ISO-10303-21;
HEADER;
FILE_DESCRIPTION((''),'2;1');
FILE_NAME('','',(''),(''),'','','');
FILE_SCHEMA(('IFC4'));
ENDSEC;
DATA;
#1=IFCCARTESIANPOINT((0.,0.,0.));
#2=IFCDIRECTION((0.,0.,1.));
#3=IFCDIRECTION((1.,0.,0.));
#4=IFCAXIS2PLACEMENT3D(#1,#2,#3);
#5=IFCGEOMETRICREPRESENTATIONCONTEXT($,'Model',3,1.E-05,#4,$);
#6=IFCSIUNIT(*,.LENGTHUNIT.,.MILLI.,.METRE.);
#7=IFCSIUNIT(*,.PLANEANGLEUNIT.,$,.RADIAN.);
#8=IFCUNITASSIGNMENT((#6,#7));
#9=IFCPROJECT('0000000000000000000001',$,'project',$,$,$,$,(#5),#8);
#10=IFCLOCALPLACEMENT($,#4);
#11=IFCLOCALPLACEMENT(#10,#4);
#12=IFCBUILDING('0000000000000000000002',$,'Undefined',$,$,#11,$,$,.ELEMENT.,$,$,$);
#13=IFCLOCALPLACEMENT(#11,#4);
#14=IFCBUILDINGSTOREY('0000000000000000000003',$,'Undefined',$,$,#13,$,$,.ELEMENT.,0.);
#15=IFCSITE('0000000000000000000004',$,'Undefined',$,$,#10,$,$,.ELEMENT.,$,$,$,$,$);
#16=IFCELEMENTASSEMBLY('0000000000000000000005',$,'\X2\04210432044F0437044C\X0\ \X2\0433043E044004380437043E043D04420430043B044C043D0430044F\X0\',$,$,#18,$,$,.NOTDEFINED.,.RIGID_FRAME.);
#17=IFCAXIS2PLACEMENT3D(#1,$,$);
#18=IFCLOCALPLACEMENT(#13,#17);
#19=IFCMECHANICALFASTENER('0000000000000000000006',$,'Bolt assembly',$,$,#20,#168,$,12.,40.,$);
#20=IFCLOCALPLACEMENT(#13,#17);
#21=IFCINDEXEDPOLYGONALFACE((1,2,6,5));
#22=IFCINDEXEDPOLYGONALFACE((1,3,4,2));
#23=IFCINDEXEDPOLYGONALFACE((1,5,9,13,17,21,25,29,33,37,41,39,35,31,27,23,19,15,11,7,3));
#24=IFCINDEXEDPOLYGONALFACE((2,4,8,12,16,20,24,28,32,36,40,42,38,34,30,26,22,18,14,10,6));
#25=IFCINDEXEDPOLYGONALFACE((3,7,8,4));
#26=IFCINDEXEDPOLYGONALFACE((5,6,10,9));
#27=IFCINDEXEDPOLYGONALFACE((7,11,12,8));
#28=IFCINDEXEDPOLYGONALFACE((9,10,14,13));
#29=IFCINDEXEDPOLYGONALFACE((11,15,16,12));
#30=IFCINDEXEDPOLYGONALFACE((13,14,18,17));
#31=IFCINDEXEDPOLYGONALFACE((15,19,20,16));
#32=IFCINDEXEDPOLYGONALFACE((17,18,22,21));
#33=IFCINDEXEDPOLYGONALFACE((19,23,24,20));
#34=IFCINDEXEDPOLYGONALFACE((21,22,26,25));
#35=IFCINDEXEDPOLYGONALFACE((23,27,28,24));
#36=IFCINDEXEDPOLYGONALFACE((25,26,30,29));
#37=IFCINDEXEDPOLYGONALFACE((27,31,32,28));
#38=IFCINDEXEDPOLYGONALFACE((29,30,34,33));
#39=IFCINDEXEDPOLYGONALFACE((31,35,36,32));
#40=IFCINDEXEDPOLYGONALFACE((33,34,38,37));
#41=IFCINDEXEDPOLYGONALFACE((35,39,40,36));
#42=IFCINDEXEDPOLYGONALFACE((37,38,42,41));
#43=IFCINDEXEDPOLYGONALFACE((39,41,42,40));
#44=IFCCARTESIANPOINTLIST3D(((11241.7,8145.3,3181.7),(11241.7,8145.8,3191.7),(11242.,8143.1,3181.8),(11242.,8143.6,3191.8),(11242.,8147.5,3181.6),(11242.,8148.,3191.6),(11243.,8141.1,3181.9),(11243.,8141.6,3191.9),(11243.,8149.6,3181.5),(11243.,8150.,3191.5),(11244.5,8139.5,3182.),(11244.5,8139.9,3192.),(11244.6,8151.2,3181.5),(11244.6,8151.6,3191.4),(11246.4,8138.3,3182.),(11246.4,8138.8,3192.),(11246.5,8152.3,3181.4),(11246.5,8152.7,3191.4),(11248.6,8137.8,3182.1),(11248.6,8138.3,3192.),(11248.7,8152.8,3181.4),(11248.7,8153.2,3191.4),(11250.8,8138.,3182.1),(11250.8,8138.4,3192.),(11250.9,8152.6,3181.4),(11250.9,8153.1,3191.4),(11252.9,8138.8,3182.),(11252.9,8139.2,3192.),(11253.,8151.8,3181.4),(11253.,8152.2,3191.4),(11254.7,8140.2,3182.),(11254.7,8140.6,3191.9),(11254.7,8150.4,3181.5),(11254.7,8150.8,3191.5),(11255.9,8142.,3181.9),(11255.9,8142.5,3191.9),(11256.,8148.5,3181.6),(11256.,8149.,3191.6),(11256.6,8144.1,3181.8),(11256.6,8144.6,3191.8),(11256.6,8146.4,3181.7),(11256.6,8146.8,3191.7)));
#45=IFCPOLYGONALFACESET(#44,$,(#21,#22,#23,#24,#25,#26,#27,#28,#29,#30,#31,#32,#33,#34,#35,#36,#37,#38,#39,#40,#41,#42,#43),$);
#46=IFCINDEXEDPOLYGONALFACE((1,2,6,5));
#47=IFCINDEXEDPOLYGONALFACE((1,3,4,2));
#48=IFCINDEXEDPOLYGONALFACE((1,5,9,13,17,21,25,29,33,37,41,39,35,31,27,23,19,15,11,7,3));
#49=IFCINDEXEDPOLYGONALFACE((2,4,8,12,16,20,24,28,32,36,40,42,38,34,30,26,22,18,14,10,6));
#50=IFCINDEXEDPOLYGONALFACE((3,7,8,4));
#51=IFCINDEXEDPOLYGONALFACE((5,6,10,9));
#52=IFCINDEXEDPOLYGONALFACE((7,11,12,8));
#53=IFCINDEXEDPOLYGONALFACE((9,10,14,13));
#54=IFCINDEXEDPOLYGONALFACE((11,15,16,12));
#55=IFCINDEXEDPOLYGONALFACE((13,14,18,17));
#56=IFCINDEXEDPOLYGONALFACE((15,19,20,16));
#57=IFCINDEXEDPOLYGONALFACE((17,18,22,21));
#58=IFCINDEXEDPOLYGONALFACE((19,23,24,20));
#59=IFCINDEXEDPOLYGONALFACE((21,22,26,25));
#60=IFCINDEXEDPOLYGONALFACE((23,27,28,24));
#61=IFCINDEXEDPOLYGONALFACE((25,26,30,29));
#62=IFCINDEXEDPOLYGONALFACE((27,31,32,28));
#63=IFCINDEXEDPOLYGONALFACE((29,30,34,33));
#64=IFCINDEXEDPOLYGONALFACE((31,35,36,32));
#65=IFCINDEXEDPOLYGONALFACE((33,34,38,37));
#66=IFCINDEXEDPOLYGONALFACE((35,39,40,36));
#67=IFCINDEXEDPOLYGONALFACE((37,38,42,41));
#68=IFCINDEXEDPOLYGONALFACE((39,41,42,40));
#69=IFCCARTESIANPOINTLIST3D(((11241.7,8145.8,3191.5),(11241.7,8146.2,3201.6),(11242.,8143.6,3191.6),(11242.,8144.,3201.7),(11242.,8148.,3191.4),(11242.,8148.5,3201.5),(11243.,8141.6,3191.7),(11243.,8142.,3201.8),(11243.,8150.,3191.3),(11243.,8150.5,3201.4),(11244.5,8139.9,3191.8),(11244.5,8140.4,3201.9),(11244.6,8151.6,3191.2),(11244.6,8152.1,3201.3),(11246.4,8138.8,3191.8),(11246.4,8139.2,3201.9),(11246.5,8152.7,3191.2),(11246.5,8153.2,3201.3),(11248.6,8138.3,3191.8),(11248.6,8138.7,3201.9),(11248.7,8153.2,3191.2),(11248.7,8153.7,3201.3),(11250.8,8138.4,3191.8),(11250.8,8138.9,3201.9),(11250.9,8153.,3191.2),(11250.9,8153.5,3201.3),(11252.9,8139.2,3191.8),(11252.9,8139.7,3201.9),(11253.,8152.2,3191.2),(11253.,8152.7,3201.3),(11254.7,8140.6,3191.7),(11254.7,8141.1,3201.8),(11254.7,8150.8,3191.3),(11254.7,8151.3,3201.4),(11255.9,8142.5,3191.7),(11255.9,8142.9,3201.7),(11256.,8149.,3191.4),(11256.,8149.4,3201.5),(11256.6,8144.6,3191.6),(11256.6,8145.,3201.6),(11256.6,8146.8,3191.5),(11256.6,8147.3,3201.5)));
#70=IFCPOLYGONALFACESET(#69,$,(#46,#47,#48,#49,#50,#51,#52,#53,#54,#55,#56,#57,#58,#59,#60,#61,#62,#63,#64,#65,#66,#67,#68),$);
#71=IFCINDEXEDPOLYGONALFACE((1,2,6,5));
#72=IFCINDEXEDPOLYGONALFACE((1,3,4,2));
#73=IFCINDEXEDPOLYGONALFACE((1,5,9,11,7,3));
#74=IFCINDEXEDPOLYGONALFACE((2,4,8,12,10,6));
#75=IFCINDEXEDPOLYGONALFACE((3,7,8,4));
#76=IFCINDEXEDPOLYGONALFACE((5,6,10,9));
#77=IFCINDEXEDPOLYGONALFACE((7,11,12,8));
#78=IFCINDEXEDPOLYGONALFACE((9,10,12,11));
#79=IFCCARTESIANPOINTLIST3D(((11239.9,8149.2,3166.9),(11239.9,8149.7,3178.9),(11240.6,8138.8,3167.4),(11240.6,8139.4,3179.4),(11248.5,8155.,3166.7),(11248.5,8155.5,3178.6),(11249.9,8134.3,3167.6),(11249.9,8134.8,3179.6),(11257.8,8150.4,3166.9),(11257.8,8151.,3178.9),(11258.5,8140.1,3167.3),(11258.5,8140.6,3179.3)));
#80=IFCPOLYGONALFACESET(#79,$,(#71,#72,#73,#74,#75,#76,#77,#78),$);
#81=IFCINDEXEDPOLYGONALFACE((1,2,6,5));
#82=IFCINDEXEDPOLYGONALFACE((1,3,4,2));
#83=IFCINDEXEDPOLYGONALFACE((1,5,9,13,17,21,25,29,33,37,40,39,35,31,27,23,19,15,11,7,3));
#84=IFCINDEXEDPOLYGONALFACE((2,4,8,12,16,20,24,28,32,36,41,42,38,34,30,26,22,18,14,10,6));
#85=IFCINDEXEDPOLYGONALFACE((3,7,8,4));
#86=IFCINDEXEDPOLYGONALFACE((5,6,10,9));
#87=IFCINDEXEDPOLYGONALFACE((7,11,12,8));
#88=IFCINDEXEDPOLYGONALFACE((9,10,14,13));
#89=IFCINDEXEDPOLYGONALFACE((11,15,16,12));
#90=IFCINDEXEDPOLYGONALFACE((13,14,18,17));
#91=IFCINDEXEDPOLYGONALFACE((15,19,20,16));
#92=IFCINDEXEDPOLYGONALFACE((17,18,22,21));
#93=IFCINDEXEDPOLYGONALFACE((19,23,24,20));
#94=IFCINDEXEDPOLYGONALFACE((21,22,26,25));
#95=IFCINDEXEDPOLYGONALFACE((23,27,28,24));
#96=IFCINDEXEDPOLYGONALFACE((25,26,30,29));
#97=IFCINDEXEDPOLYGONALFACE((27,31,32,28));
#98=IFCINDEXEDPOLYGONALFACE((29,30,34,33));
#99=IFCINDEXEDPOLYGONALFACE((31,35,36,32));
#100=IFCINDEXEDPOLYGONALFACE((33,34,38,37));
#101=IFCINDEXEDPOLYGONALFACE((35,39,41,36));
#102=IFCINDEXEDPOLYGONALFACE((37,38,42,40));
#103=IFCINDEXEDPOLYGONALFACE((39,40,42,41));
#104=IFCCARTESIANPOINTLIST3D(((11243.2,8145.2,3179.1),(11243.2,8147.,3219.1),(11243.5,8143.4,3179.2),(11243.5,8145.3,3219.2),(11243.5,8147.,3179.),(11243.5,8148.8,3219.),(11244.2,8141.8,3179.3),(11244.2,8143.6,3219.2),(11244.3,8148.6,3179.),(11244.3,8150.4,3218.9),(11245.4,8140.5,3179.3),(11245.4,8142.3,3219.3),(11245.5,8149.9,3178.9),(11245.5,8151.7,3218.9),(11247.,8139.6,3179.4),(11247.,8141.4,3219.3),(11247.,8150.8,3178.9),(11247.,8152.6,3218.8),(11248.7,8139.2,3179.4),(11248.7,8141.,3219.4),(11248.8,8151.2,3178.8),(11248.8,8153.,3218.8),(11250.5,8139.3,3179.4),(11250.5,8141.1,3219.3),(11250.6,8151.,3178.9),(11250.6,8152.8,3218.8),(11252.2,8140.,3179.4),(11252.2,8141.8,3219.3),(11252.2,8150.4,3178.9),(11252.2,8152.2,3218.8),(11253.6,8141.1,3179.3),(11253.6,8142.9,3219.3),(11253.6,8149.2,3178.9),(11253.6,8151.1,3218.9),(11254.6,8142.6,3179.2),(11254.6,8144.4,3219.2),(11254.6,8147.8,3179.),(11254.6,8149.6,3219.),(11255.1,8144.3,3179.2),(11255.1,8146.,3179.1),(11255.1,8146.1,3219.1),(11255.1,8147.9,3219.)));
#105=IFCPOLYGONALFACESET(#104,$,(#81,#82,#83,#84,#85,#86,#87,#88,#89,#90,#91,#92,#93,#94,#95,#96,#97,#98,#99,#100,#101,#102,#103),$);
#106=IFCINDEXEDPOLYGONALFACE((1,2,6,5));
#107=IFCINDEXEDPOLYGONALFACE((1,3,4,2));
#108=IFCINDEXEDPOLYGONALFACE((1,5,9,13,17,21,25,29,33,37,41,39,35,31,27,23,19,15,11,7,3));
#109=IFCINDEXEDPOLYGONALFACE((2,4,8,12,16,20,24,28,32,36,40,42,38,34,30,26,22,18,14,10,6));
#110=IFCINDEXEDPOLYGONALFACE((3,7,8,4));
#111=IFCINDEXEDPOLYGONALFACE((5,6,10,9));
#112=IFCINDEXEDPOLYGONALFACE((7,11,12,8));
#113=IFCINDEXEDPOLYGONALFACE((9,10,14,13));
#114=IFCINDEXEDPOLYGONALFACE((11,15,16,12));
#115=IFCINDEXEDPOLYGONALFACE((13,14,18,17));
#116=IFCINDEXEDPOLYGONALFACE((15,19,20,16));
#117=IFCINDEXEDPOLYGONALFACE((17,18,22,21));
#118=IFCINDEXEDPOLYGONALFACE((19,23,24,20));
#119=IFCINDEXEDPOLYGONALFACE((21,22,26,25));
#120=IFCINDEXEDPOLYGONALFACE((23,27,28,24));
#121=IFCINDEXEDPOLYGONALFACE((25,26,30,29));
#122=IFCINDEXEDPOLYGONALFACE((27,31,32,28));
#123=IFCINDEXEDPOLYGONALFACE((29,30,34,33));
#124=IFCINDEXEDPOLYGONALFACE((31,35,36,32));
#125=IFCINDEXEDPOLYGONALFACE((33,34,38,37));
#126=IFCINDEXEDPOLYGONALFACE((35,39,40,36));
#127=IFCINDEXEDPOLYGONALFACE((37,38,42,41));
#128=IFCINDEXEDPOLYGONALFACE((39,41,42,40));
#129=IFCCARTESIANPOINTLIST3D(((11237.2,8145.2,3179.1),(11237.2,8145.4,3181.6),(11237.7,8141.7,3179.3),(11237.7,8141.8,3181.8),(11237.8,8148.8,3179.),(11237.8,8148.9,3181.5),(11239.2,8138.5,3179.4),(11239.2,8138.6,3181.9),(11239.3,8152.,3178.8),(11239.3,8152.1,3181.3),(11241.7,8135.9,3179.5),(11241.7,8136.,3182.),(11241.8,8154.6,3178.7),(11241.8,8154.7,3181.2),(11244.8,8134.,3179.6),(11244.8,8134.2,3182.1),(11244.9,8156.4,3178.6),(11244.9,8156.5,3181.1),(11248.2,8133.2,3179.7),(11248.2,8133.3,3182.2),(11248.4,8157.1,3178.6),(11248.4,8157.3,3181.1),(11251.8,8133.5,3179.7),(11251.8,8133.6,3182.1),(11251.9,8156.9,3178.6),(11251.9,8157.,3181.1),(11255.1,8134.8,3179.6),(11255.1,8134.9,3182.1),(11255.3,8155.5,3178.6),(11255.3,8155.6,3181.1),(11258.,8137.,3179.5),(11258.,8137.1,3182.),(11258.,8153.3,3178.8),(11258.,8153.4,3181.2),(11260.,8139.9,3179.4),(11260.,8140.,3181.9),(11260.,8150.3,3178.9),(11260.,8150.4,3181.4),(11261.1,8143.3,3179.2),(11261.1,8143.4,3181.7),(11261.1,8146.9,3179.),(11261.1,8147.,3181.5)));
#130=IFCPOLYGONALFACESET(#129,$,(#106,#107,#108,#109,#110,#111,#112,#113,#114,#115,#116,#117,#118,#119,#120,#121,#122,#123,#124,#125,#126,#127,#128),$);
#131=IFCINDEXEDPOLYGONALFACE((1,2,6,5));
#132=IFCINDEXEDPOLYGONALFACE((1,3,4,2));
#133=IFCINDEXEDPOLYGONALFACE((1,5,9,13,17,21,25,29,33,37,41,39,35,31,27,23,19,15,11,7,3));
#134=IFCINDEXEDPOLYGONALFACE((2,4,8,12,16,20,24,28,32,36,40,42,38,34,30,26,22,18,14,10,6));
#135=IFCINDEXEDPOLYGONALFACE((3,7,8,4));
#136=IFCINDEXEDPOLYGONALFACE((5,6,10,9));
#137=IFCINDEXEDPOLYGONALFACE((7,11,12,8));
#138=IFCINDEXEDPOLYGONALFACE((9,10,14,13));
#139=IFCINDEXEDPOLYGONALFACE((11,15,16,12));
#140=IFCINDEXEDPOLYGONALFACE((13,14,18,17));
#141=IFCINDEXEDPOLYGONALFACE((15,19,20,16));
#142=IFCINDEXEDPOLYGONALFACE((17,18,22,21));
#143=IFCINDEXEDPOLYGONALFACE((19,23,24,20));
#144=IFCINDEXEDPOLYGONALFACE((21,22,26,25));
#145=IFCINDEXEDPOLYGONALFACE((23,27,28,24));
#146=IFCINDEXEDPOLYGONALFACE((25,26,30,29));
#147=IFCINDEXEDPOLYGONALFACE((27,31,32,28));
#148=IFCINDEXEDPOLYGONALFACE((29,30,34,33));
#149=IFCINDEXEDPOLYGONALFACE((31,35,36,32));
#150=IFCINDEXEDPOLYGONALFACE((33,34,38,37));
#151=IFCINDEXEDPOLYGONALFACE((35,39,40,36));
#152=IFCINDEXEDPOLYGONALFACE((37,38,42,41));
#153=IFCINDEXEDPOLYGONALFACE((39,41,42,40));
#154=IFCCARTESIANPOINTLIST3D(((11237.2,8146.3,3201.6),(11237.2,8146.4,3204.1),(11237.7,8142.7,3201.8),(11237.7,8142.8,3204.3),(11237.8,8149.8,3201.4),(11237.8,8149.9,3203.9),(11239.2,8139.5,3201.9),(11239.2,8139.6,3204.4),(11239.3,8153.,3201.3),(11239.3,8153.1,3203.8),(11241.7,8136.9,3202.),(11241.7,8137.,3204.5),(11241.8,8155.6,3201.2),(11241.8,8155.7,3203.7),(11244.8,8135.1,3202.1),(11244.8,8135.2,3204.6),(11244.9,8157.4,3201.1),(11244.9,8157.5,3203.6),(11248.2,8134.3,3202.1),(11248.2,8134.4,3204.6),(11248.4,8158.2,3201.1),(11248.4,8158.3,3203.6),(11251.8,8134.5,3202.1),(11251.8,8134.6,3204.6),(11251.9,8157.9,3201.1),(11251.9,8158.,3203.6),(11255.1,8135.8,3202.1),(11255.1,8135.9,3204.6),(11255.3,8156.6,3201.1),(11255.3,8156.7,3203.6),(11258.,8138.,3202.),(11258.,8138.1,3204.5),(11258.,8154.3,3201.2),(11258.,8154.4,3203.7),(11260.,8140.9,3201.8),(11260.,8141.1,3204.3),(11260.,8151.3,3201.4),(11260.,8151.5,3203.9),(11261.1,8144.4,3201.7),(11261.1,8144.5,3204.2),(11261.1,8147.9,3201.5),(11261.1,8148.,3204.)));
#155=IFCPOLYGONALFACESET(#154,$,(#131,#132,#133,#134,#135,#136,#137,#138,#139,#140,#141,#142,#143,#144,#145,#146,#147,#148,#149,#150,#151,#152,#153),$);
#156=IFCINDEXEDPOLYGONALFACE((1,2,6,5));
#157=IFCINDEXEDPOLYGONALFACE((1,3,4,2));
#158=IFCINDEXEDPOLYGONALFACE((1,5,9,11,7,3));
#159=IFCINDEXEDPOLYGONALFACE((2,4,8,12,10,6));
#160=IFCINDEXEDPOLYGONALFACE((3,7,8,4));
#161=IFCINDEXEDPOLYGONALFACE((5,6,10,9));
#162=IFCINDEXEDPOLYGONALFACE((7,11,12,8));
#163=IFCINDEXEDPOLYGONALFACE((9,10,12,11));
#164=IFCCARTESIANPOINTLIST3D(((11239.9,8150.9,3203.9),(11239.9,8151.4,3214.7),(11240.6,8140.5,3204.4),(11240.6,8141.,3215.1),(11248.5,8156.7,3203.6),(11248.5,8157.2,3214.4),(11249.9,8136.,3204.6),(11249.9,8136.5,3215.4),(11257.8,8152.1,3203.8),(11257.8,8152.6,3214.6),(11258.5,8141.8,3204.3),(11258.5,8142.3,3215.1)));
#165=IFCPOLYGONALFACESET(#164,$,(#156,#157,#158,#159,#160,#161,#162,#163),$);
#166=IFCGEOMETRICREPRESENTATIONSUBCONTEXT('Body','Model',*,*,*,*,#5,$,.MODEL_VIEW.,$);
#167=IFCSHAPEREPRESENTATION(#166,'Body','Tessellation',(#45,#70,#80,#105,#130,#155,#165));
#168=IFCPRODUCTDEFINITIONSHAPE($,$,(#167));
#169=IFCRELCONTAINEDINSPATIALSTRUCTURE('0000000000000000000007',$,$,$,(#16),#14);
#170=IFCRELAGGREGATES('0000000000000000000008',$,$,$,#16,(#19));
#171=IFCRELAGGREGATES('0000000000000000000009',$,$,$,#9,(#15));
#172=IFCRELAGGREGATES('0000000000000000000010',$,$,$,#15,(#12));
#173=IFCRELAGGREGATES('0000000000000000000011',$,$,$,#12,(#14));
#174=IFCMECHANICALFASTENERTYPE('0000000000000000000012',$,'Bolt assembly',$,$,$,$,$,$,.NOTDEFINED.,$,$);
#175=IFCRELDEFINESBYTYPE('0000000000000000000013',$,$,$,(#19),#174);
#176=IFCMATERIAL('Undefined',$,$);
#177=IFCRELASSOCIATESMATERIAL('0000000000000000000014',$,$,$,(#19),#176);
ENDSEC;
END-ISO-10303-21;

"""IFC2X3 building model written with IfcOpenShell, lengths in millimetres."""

from ifc_helpers import new_model, si_unit, frame, origin_with_axes, origin_2d_with_axis, place, context, subcontext, project, spatial, polyline, circle, outline, extrude, source, transform, mapped, material, type_object, element, aggregate, save


model = new_model("IFC2X3")

# Units and contexts
model_context = context("Model", 3, precision=1e-05, world=origin_with_axes())
body_context = subcontext(model_context, "Body", "Model", "MODEL_VIEW")
ifc_project = project(units=[si_unit("LENGTHUNIT", "METRE", prefix="MILLI"), si_unit("PLANEANGLEUNIT", "RADIAN")], contexts=[model_context])

# Site, building, storey
site_placement = place(None, origin_with_axes())
site = spatial("IfcSite", under=ifc_project, at=site_placement, Name="Undefined", CompositionType="ELEMENT")
building_placement = place(site_placement, origin_with_axes())
building = spatial("IfcBuilding", under=site, at=building_placement, Name="Undefined", CompositionType="ELEMENT")
storey_placement = place(building_placement, origin_with_axes())
storey = spatial("IfcBuildingStorey", under=building, at=storey_placement, Name="Undefined", CompositionType="ELEMENT", Elevation=0.0)

# Element assembly
assembly_1_placement = place(storey_placement, origin_with_axes())
assembly_1 = element("IfcElementAssembly", 1, at=assembly_1_placement, inside=storey, Name="Связь горизонтальная", AssemblyPlace="NOTDEFINED", PredefinedType="RIGID_FRAME")

# Mechanical fastener
ifc_material_1 = material(Name="Undefined")
mechanical_fastener_type = type_object("IfcMechanicalFastenerType", Name="Bolt assembly")
shared_shape_1 = source(origin_with_axes(), body_context, "Body", "SweptSolid", [
    extrude(circle(Radius=7.5, at=origin_2d_with_axis()), frame((0.0, 0.1, 0.0), z_axis=(0.0, 1.0, 0.0), x_axis=(1.0, 0.0, 0.0)), (0.0, 0.0, 1.0), 10.0),
    extrude(circle(Radius=7.5, at=origin_2d_with_axis()), frame((0.0, 9.9, 0.0), z_axis=(0.0, 1.0, 0.0), x_axis=(1.0, 0.0, 0.0)), (0.0, 0.0, 1.0), 10.1),
    extrude(outline(polyline([(10.4, 0.0), (5.2, 9.0), (-5.2, 9.0), (-10.4, 0.0), (-5.2, -9.0), (5.2, -9.0), (10.4, 0.0)])), frame((0.0, -14.5, 0.0), z_axis=(0.0, 1.0, 0.0), x_axis=(1.0, 0.0, 0.0)), (0.0, 0.0, 1.0), 12.0),
    extrude(circle(Radius=6.0, at=origin_2d_with_axis()), frame((0.0, -2.5, 0.0), z_axis=(0.0, 1.0, 0.0), x_axis=(1.0, 0.0, 0.0)), (0.0, 0.0, 1.0), 40.0),
    extrude(circle(Radius=12.0, at=origin_2d_with_axis()), frame((0.0, -2.5, 0.0), z_axis=(0.0, 1.0, 0.0), x_axis=(1.0, 0.0, 0.0)), (0.0, 0.0, 1.0), 2.5),
    extrude(circle(Radius=12.0, at=origin_2d_with_axis()), frame((0.0, 20.0, 0.0), z_axis=(0.0, 1.0, 0.0), x_axis=(1.0, 0.0, 0.0)), (0.0, 0.0, 1.0), 2.5),
    extrude(outline(polyline([(10.4, 0.0), (5.2, 9.0), (-5.2, 9.0), (-10.4, 0.0), (-5.2, -9.0), (5.2, -9.0), (10.4, 0.0)])), frame((0.0, 22.5, 0.0), z_axis=(0.0, 1.0, 0.0), x_axis=(1.0, 0.0, 0.0)), (0.0, 0.0, 1.0), 10.8),
])
mechanical_fastener_1_placement = place(assembly_1_placement, frame((11249.2, 8145.3, 3181.6), z_axis=(-0.558918, 0.828367, -0.037653), x_axis=(-0.829223, -0.558342, 0.025379)))
mechanical_fastener_1 = element("IfcMechanicalFastener", 2, at=mechanical_fastener_1_placement, type_object=mechanical_fastener_type, material=ifc_material_1, Name="Bolt assembly", NominalDiameter=12.0, NominalLength=40.0, context=body_context, shape_type="MappedRepresentation", body=[
    mapped(shared_shape_1, transform((0.0, 0.0, 0.0))),
])
aggregate(assembly_1, [mechanical_fastener_1])

save(model, "model.ifc")
